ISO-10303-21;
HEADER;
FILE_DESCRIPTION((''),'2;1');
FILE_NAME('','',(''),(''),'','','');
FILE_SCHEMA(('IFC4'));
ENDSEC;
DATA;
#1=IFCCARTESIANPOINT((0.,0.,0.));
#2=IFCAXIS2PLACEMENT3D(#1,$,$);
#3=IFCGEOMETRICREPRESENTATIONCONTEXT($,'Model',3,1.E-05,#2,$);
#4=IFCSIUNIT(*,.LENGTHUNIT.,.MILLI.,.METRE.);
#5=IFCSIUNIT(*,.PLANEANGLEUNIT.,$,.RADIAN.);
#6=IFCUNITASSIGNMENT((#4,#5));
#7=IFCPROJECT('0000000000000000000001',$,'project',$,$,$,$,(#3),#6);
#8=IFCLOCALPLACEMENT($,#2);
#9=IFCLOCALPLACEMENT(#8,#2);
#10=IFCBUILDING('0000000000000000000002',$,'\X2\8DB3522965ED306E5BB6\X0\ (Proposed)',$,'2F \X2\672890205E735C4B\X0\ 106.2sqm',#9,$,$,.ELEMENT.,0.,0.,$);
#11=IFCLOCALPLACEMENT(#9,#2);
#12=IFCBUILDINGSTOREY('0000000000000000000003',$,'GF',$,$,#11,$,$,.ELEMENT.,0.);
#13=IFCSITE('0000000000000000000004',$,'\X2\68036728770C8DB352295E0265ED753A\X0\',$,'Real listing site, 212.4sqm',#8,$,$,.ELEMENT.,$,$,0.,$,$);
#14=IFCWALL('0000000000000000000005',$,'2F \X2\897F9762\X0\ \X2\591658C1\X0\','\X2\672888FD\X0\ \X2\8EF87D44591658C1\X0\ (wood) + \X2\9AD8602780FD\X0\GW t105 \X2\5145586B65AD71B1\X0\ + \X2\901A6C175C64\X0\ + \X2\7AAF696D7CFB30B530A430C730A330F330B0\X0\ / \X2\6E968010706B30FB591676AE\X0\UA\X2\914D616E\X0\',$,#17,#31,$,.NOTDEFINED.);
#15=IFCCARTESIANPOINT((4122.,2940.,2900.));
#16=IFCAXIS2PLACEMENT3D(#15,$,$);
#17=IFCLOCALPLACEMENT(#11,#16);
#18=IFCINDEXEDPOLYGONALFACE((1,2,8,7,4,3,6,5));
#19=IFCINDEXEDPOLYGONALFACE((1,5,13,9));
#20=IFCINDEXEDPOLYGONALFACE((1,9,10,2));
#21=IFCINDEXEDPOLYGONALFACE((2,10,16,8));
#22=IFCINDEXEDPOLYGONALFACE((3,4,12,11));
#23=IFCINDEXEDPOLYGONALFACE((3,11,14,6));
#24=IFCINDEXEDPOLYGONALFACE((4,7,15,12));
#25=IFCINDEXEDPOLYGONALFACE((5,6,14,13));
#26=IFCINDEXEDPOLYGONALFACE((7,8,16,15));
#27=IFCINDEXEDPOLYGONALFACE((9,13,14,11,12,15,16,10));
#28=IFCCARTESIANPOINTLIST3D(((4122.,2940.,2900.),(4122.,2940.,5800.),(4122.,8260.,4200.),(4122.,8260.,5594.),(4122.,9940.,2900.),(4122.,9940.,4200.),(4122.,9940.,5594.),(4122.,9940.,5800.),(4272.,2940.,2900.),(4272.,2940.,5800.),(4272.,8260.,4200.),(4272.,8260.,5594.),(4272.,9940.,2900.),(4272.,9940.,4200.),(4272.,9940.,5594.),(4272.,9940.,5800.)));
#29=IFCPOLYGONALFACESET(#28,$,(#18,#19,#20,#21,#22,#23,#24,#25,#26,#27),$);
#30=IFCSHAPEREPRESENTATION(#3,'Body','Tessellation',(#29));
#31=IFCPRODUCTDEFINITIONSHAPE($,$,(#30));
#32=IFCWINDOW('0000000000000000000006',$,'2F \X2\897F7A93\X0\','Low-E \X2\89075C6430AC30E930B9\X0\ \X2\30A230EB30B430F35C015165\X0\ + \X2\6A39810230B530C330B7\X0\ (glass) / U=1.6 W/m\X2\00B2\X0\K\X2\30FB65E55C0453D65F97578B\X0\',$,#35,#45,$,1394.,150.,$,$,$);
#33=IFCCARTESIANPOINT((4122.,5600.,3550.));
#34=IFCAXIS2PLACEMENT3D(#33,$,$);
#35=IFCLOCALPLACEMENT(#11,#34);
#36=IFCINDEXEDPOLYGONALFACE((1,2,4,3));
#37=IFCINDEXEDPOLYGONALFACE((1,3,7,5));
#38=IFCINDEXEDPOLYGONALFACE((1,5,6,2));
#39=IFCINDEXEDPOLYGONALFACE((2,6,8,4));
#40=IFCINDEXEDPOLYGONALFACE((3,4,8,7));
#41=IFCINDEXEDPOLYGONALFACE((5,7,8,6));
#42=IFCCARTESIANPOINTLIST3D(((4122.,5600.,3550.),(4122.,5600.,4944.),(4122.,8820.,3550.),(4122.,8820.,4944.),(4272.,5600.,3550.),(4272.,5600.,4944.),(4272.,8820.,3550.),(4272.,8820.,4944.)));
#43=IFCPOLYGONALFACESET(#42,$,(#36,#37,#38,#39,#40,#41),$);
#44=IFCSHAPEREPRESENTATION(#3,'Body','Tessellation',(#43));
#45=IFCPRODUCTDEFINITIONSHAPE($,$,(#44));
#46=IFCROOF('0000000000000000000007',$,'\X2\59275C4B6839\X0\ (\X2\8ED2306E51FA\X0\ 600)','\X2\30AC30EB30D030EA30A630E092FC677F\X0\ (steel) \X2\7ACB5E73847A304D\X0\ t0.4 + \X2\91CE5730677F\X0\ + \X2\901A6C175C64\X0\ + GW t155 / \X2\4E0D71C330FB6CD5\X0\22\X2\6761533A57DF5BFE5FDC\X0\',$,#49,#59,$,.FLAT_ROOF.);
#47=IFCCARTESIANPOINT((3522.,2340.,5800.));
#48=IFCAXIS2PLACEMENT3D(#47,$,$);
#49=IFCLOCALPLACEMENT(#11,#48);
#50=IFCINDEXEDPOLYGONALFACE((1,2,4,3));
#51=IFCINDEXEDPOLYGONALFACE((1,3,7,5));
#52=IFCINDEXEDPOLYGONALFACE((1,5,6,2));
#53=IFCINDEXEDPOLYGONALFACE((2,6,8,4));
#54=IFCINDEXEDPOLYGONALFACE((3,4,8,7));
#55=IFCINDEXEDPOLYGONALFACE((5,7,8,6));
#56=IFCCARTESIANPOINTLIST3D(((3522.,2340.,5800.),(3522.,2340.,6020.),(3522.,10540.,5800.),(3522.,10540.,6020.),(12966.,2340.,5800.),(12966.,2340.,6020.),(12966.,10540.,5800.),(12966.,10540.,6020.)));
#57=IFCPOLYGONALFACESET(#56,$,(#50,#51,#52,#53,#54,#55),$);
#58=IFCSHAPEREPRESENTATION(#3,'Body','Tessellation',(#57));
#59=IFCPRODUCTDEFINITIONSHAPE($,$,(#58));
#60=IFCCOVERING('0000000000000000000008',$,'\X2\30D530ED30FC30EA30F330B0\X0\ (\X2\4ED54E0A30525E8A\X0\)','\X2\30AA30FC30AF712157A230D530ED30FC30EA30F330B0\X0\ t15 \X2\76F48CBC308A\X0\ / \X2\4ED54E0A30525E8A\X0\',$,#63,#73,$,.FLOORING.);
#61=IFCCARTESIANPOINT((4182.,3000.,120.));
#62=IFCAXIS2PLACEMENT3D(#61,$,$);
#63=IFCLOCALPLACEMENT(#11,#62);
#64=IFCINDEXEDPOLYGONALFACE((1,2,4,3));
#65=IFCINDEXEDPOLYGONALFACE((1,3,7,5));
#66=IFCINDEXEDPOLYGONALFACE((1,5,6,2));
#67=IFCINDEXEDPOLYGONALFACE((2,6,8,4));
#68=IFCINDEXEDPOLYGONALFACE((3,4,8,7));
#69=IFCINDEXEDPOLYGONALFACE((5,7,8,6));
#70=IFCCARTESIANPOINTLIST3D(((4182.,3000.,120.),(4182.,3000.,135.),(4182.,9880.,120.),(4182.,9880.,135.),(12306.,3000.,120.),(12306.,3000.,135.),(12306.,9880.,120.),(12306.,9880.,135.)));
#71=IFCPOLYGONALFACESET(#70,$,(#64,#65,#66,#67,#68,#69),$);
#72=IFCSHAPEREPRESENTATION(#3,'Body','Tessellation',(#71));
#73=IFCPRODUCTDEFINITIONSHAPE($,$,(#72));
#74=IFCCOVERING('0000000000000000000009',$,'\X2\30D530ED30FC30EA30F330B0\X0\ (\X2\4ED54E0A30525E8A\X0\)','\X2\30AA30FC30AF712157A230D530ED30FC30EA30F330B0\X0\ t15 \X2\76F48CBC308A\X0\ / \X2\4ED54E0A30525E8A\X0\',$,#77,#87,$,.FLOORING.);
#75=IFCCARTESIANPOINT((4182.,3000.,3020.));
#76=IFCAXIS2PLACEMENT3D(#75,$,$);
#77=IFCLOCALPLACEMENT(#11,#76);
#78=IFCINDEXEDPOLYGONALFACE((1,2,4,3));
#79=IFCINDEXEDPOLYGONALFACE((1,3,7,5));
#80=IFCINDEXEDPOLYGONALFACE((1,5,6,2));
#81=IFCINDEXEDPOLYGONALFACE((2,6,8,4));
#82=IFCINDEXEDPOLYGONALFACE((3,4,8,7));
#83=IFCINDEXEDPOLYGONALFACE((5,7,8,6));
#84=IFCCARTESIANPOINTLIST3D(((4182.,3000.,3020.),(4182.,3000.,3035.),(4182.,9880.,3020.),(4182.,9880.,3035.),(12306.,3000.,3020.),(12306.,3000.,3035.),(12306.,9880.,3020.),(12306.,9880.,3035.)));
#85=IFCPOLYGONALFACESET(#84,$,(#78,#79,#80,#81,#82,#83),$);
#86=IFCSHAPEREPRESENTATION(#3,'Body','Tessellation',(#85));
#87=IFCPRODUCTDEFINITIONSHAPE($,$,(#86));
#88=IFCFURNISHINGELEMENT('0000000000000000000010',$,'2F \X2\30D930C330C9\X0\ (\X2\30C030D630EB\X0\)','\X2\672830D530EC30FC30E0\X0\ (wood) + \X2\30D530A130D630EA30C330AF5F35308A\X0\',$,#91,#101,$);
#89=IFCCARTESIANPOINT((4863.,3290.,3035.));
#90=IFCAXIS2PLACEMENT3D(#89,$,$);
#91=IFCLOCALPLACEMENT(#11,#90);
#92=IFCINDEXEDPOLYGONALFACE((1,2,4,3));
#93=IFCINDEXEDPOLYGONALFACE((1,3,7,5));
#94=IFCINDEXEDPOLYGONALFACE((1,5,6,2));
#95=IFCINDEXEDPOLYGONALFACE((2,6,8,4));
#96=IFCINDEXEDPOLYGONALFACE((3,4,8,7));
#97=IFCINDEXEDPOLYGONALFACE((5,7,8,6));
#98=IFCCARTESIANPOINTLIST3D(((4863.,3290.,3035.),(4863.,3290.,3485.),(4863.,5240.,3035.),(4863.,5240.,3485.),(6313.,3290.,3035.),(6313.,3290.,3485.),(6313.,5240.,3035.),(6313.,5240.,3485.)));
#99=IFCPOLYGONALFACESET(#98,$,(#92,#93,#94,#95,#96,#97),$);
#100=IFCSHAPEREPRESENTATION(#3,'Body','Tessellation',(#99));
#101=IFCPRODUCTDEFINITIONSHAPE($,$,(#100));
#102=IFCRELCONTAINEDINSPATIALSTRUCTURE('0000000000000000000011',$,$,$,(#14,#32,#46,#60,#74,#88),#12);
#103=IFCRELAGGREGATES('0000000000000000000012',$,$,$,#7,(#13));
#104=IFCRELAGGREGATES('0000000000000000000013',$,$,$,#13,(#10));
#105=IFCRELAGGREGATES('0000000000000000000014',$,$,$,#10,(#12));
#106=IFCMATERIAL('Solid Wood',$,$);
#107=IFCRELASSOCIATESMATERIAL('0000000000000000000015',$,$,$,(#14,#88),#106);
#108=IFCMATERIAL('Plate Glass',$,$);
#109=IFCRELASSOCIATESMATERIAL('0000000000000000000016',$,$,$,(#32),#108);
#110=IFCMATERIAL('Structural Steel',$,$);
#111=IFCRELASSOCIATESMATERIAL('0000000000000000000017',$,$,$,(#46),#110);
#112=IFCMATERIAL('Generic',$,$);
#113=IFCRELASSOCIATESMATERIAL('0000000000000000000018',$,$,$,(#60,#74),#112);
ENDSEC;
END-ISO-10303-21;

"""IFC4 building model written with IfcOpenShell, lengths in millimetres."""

from ifc_helpers import new_model, si_unit, frame, frame_2d, origin, place, context, project, spatial, rectangle, extrude, material, element, fill, save


model = new_model("IFC4")

# Units and contexts
model_context = context("Model", 3, precision=1e-05, world=origin())
ifc_project = project(units=[si_unit("LENGTHUNIT", "METRE", prefix="MILLI"), si_unit("PLANEANGLEUNIT", "RADIAN")], contexts=[model_context])

# Site, building, storey
site_placement = place(None, origin())
site = spatial("IfcSite", under=ifc_project, at=site_placement, Name="栃木県足利市旭町", ObjectType="Real listing site, 212.4sqm", CompositionType="ELEMENT", RefElevation=0.0)
building_placement = place(site_placement, origin())
building = spatial("IfcBuilding", under=site, at=building_placement, Name="足利旭の家 (Proposed)", ObjectType="2F 木造平屋 106.2sqm", CompositionType="ELEMENT", ElevationOfRefHeight=0.0, ElevationOfTerrain=0.0)
storey_placement = place(building_placement, origin())
storey = spatial("IfcBuildingStorey", under=building, at=storey_placement, Name="GF", CompositionType="ELEMENT", Elevation=0.0)

# Shared definitions
ifc_material_1 = material(Name="Solid Wood")

# Shared definitions
ifc_material_2 = material(Name="Plate Glass")

# Wall, opening, window
wall_1_placement = place(storey_placement, frame((4122.0, 2940.0, 2900.0)))
wall_1 = element("IfcWall", 1, at=wall_1_placement, inside=storey, material=ifc_material_1, Name="2F 西面 外壁", Description="木製 軸組外壁 (wood) + 高性能GW t105 充填断熱 + 通気層 + 窯業系サイディング / 準耐火・外皮UA配慮", PredefinedType="NOTDEFINED", context=model_context, shape_type="SweptSolid", body=[
    extrude(rectangle(XDim=150.0, YDim=7000.0, at=frame_2d((75.0, 3500.0))), frame((4122.0, 2940.0, 2900.0)), (0.0, 0.0, 1.0), 2900.0),
])
opening_1_placement = place(storey_placement, frame((4122.0, 5600.0, 3550.0)))
opening_1 = element("IfcOpeningElement", 2, at=opening_1_placement, cuts=wall_1, PredefinedType="NOTDEFINED", context=model_context, shape_type="SweptSolid", body=[
    extrude(rectangle(XDim=150.0, YDim=3220.0, at=frame_2d((75.0, 1610.0))), frame((4122.0, 5600.0, 3550.0)), (0.0, 0.0, 1.0), 1394.0),
])
window_1_placement = place(storey_placement, frame((4122.0, 5600.0, 3550.0)))
window_1 = element("IfcWindow", 3, at=window_1_placement, inside=storey, material=ifc_material_2, Name="2F 西窓", Description="Low-E 複層ガラス アルゴン封入 + 樹脂サッシ (glass) / U=1.6 W/m²K・日射取得型", OverallHeight=1394.0, OverallWidth=150.0, context=model_context, shape_type="SweptSolid", body=[
    extrude(rectangle(XDim=150.0, YDim=3220.0, at=frame_2d((75.0, 1610.0))), frame((4122.0, 5600.0, 3550.0)), (0.0, 0.0, 1.0), 1394.0),
])
fill(opening_1, window_1)

# Roof
ifc_material_3 = material(Name="Structural Steel")
roof_placement = place(storey_placement, frame((3522.0, 2340.0, 5800.0)))
element("IfcRoof", 4, at=roof_placement, inside=storey, material=ifc_material_3, Name="大屋根 (軒の出 600)", Description="ガルバリウム鋼板 (steel) 立平葺き t0.4 + 野地板 + 通気層 + GW t155 / 不燃・法22条区域対応", PredefinedType="FLAT_ROOF", context=model_context, shape_type="SweptSolid", body=[
    extrude(rectangle(XDim=9444.0, YDim=8200.0, at=frame_2d((4722.0, 4100.0))), frame((3522.0, 2340.0, 5800.0)), (0.0, 0.0, 1.0), 220.0),
])

# Coverings
ifc_material_4 = material(Name="Generic")
covering_1_placement = place(storey_placement, frame((4182.0, 3000.0, 120.0)))
element("IfcCovering", 5, at=covering_1_placement, inside=storey, material=ifc_material_4, Name="フローリング (仕上げ床)", Description="オーク無垢フローリング t15 直貼り / 仕上げ床", PredefinedType="FLOORING", context=model_context, shape_type="SweptSolid", body=[
    extrude(rectangle(XDim=8124.0, YDim=6880.0, at=frame_2d((4062.0, 3440.0))), frame((4182.0, 3000.0, 120.0)), (0.0, 0.0, 1.0), 15.0),
])
covering_2_placement = place(storey_placement, frame((4182.0, 3000.0, 3020.0)))
element("IfcCovering", 6, at=covering_2_placement, inside=storey, material=ifc_material_4, Name="フローリング (仕上げ床)", Description="オーク無垢フローリング t15 直貼り / 仕上げ床", PredefinedType="FLOORING", context=model_context, shape_type="SweptSolid", body=[
    extrude(rectangle(XDim=8124.0, YDim=6880.0, at=frame_2d((4062.0, 3440.0))), frame((4182.0, 3000.0, 3020.0)), (0.0, 0.0, 1.0), 15.0),
])

# Furnishing element
furnishing_placement = place(storey_placement, frame((4863.0, 3290.0, 3035.0)))
element("IfcFurnishingElement", 7, at=furnishing_placement, inside=storey, material=ifc_material_1, Name="2F ベッド (ダブル)", Description="木フレーム (wood) + ファブリック張り", context=model_context, shape_type="SweptSolid", body=[
    extrude(rectangle(XDim=1450.0, YDim=1950.0, at=frame_2d((725.0, 975.0))), frame((4863.0, 3290.0, 3035.0)), (0.0, 0.0, 1.0), 450.0),
])

save(model, "model.ifc")
